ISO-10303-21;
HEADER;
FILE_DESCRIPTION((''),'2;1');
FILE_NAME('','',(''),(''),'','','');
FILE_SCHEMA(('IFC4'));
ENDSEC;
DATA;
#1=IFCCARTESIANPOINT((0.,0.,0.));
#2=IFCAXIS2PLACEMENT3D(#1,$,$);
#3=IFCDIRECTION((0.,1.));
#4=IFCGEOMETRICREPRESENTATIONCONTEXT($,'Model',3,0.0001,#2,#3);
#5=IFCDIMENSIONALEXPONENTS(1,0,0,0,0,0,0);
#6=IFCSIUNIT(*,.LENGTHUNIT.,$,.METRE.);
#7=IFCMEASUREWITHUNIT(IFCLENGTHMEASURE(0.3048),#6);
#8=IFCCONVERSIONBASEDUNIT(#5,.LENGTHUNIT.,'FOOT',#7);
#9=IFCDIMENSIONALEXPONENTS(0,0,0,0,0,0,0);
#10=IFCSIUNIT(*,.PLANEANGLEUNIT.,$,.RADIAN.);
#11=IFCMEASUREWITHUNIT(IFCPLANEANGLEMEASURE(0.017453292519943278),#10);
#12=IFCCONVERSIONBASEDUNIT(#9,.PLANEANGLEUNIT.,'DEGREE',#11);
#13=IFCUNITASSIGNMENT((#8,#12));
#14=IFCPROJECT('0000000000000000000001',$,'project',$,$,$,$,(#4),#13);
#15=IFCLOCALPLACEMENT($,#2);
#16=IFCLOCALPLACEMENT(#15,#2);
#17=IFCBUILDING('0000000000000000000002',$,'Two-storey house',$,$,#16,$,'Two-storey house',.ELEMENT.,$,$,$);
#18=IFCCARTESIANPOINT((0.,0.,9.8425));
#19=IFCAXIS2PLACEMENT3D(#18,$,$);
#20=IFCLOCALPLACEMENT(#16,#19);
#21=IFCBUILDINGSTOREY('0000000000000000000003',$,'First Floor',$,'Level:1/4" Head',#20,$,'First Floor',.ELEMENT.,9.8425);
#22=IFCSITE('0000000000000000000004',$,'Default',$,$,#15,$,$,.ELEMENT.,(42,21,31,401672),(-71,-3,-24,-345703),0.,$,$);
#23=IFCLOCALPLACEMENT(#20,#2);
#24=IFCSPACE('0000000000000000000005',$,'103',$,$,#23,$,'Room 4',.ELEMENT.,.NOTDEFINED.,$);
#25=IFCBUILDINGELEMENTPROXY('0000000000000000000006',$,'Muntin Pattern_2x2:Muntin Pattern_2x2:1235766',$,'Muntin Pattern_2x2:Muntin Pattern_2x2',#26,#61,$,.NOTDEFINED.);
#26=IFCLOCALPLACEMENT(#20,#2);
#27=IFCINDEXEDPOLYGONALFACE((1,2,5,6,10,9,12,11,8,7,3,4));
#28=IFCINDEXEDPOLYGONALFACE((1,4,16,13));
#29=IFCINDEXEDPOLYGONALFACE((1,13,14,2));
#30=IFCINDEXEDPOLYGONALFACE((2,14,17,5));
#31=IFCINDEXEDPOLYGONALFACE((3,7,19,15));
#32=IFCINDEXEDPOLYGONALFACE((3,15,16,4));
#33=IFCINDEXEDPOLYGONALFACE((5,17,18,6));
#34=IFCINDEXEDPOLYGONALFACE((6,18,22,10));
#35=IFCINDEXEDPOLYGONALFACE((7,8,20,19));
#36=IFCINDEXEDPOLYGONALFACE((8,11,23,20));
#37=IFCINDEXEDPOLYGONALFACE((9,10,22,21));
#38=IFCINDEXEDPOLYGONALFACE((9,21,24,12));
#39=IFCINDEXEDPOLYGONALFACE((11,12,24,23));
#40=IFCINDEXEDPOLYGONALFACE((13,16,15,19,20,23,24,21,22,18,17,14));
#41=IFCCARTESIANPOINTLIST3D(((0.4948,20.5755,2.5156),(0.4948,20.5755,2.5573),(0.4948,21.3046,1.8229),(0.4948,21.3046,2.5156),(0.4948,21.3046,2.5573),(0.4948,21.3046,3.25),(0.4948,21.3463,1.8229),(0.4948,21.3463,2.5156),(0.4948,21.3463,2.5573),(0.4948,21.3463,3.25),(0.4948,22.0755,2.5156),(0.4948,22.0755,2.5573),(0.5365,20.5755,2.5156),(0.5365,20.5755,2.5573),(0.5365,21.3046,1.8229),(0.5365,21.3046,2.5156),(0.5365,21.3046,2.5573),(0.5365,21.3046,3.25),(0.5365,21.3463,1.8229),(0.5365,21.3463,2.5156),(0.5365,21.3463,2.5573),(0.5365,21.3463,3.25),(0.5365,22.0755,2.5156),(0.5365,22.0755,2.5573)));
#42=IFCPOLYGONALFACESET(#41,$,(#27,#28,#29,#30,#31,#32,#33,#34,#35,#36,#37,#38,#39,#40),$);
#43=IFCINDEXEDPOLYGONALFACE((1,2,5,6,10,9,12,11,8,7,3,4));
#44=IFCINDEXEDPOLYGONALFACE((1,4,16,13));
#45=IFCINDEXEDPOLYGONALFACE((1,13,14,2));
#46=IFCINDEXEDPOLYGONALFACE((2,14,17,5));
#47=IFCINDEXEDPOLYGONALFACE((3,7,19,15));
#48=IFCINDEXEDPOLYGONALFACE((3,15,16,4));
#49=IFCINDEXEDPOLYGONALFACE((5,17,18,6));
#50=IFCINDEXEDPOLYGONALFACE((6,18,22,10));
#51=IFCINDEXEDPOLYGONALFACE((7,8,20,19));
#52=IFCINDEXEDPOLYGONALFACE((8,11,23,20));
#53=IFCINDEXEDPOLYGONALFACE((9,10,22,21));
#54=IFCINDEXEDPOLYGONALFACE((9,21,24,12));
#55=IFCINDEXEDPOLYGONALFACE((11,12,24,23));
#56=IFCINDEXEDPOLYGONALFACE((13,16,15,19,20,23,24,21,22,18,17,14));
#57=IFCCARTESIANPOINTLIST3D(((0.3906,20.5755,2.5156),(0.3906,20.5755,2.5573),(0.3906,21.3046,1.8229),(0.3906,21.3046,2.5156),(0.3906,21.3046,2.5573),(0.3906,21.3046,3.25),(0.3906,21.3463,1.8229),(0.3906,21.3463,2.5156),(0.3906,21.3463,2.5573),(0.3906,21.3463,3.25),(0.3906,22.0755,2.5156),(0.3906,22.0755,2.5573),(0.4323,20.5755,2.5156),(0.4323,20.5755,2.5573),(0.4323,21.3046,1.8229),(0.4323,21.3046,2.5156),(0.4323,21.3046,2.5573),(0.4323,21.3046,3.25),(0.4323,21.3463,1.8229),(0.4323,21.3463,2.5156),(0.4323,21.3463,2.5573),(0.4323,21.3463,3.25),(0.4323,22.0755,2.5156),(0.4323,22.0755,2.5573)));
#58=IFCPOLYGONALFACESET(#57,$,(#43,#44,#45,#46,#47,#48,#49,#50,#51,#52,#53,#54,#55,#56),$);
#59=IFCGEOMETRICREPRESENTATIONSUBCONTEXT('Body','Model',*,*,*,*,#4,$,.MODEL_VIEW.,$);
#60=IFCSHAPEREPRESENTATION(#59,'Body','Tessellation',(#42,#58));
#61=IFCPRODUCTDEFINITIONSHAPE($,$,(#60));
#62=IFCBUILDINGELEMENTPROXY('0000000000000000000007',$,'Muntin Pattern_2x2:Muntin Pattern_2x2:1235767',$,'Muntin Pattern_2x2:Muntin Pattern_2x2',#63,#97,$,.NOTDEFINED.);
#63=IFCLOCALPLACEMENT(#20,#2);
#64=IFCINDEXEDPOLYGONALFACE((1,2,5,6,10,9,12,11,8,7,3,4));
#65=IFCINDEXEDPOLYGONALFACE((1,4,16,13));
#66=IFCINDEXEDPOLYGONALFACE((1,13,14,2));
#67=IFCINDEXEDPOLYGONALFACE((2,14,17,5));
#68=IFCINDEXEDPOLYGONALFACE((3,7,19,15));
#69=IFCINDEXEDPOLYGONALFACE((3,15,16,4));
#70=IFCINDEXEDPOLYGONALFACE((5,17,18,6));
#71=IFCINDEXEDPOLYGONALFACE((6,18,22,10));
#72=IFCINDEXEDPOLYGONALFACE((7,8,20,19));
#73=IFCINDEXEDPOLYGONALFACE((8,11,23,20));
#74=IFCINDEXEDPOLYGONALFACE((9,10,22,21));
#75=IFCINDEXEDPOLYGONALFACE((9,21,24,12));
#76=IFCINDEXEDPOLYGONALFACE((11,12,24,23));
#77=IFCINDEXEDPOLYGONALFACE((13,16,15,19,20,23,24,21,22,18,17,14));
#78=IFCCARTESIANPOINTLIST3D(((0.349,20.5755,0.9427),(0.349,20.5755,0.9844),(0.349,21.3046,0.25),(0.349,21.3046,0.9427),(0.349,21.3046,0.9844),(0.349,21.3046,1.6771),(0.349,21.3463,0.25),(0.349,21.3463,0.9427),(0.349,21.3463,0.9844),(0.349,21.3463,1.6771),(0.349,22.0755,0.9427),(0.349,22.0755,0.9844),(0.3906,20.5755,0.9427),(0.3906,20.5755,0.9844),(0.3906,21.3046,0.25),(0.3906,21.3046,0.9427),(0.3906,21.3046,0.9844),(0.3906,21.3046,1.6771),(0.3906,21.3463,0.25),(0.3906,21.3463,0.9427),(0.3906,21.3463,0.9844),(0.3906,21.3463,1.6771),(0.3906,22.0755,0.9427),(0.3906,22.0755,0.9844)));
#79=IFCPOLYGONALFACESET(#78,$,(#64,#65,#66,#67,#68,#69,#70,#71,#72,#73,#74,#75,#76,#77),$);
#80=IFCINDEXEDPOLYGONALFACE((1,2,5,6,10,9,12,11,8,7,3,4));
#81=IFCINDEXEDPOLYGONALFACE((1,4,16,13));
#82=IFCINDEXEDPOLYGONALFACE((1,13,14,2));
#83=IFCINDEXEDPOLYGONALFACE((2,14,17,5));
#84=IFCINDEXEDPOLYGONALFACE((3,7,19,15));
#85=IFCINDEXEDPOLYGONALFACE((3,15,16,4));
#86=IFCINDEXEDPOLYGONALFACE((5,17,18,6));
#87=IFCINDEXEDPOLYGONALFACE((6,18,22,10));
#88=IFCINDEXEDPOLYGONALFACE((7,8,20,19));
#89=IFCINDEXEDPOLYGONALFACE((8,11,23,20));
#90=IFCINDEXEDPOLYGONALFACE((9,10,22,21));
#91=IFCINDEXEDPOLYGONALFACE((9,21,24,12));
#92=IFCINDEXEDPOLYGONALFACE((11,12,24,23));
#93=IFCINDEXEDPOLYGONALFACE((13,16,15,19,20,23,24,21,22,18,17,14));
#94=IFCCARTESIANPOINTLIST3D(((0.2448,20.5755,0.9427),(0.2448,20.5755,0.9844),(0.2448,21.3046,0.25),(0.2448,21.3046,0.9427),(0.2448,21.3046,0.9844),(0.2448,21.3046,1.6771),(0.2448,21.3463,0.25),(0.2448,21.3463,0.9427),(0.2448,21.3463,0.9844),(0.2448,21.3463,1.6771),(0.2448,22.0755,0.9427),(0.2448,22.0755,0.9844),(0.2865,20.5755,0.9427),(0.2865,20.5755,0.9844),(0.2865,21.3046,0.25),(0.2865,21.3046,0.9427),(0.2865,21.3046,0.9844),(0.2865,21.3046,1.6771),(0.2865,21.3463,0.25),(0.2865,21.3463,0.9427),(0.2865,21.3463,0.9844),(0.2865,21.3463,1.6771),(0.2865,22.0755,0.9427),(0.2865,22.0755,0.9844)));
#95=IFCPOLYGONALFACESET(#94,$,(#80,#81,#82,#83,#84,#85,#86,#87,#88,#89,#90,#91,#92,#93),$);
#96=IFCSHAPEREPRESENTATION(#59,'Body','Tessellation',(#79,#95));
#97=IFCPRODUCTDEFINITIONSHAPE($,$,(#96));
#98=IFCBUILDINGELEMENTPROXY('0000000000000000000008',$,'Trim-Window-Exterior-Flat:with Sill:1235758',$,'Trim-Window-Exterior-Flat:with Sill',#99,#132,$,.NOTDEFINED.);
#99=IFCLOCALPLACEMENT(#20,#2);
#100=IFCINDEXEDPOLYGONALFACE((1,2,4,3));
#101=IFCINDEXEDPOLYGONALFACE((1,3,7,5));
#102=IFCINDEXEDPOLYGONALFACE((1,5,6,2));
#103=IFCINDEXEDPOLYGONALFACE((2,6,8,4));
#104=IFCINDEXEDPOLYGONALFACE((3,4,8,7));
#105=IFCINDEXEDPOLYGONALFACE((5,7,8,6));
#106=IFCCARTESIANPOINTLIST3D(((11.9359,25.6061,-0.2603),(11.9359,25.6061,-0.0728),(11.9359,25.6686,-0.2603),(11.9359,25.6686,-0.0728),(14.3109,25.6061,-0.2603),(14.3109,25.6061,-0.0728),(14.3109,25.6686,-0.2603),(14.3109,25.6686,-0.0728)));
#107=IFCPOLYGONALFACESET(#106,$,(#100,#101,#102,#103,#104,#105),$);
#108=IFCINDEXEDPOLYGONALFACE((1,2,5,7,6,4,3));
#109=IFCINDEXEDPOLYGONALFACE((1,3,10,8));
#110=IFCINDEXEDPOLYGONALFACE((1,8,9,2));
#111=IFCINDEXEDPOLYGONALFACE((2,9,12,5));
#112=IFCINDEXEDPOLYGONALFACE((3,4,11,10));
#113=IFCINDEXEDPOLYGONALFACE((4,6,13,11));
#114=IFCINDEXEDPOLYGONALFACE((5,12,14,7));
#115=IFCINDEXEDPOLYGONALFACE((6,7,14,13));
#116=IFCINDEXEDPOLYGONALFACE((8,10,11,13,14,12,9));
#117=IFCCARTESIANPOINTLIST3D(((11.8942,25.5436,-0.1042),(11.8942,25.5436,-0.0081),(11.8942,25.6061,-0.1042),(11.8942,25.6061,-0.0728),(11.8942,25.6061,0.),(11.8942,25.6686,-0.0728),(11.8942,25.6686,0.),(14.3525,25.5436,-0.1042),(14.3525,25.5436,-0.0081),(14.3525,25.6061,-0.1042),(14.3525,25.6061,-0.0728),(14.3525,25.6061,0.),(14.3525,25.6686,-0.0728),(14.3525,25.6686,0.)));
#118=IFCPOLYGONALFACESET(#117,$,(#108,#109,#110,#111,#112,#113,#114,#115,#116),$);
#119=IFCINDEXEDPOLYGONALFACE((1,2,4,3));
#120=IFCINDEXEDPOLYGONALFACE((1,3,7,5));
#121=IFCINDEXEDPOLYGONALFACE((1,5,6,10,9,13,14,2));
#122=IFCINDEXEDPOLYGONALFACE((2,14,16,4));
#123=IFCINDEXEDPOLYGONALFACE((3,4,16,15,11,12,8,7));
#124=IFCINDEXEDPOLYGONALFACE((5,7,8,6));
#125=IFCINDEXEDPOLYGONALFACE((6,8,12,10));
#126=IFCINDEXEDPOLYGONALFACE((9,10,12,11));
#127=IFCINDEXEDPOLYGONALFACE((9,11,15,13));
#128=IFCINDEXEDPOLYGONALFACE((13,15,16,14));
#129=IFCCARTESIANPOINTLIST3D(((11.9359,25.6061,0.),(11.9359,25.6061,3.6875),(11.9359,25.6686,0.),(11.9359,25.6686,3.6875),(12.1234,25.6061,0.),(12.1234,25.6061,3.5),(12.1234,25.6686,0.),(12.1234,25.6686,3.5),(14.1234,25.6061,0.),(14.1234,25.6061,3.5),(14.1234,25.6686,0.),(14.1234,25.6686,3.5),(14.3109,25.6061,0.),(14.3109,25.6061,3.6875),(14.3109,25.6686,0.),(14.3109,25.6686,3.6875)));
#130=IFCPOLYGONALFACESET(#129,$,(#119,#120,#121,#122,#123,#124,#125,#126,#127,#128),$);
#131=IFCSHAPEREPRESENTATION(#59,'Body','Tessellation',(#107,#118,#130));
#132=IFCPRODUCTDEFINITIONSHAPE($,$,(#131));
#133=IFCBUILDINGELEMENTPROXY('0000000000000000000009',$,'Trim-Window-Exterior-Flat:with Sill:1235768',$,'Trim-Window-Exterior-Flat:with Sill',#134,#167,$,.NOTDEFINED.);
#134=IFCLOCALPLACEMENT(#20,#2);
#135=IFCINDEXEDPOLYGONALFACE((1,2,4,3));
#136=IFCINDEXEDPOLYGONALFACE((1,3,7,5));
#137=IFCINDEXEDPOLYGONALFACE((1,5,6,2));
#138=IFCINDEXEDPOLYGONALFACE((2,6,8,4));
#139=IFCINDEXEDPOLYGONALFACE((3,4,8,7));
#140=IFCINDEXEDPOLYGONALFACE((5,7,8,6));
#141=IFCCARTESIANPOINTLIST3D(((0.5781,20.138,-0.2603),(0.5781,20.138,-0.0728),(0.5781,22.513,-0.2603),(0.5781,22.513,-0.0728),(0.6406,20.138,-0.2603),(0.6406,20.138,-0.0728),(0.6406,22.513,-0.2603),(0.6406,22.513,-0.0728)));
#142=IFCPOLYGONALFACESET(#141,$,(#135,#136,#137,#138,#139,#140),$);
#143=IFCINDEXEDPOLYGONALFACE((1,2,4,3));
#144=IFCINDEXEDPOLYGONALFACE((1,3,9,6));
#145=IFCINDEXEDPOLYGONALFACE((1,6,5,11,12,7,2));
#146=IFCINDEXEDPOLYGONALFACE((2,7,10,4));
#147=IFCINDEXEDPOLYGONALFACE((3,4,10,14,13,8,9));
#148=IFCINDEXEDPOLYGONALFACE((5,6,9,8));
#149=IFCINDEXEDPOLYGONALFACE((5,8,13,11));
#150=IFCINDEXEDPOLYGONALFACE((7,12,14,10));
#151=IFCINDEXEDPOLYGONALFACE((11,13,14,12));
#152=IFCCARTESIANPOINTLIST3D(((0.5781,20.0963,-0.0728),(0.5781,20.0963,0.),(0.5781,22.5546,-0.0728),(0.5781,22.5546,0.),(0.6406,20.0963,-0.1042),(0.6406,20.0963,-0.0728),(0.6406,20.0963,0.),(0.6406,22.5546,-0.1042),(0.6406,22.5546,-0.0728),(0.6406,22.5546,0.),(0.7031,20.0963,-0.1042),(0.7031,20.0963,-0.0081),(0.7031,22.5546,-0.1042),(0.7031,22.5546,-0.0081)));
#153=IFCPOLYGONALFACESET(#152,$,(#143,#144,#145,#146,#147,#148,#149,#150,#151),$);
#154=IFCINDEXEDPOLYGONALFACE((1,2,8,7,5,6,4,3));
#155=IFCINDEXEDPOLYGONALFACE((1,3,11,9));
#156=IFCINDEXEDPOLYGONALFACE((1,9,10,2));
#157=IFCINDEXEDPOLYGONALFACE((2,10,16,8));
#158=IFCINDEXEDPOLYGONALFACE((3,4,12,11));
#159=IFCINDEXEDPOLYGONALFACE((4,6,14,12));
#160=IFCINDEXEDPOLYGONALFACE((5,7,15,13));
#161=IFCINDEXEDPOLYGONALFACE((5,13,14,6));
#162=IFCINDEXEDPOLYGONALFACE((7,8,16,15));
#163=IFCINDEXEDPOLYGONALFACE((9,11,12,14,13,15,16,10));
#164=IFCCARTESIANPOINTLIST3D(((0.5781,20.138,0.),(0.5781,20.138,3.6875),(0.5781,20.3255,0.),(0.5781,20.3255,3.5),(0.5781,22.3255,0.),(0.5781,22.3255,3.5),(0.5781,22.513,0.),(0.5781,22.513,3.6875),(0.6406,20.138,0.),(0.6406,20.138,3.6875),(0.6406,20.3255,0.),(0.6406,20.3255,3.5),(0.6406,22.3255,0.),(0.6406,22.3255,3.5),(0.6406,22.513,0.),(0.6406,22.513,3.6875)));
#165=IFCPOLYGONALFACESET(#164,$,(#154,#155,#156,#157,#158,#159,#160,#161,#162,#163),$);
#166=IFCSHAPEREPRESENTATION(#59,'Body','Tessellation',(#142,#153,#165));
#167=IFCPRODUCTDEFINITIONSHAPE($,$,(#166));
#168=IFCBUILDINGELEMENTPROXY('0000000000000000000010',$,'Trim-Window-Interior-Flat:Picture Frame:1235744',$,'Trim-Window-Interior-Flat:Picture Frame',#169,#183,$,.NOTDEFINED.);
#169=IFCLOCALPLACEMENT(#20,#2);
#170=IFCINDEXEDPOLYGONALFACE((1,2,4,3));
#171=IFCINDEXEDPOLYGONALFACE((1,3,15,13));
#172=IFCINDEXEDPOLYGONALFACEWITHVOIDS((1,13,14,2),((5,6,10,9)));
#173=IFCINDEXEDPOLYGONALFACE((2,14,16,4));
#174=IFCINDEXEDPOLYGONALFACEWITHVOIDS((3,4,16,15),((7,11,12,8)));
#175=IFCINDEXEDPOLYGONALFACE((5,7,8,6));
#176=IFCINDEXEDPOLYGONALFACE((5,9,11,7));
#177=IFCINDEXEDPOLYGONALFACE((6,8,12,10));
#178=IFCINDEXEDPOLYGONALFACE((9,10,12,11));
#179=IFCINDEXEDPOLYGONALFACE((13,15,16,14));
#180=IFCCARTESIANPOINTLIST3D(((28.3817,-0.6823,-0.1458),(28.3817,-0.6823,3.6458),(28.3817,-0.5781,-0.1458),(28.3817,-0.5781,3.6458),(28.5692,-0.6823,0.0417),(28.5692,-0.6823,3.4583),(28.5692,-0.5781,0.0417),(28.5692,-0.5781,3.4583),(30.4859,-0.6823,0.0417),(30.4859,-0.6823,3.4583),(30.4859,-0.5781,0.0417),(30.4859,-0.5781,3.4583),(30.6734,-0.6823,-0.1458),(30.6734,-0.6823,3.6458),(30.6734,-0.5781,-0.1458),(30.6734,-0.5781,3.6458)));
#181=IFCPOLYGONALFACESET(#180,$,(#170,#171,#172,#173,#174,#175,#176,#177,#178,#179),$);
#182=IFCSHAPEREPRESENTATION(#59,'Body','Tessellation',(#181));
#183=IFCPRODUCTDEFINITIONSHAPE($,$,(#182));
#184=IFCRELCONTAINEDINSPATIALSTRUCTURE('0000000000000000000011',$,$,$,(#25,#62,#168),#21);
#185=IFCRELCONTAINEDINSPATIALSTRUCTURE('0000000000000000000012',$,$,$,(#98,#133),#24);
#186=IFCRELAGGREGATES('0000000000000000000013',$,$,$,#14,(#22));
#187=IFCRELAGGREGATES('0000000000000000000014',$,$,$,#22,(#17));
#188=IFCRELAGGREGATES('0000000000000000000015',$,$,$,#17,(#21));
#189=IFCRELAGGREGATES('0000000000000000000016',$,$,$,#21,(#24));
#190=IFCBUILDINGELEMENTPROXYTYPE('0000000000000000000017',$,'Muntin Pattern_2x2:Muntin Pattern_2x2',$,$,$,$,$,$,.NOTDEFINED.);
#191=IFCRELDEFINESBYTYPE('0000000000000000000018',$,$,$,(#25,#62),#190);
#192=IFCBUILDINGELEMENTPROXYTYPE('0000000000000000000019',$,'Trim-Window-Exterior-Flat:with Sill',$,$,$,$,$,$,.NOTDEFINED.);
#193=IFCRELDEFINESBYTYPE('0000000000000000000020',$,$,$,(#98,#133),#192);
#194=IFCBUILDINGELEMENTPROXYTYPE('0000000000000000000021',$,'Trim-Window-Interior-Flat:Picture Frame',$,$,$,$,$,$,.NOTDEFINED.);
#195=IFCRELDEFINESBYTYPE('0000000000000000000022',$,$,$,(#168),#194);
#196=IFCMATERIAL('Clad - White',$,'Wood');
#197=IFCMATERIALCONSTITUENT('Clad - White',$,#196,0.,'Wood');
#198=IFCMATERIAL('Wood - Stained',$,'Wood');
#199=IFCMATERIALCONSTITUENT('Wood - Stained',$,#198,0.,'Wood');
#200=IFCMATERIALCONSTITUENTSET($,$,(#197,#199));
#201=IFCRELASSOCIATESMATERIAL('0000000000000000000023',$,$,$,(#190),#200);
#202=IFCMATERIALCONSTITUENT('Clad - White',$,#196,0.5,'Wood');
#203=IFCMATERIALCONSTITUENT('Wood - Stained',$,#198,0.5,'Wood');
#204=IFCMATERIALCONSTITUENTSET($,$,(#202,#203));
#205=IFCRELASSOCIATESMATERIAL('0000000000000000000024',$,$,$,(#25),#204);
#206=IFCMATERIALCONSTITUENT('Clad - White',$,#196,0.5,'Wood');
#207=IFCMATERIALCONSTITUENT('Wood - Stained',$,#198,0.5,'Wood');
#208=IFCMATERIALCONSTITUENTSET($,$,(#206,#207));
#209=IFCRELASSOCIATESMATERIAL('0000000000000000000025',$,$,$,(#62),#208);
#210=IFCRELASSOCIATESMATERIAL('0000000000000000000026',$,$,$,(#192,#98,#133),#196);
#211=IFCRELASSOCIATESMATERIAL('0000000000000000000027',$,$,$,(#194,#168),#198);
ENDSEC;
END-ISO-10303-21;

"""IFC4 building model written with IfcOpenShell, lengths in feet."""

from ifc_helpers import new_model, entity, si_unit, converted_unit, direction, frame, origin, place, context, subcontext, project, spatial, indexed_curve, outline, extrude, source, transform, mapped, material, constituent, constituent_set, type_object, type_shapes, element, save


model = new_model("IFC4")

# Units and contexts
model_context = context("Model", 3, precision=0.0001, world=origin(), true_north=direction((0.0, 1.0)))
body_context = subcontext(model_context, "Body", "Model", "MODEL_VIEW")
ifc_project = project(units=[converted_unit("LENGTHUNIT", "FOOT", entity("IfcLengthMeasure", 0.3048), si_unit("LENGTHUNIT", "METRE"), dimensions=[1, 0, 0, 0, 0, 0, 0]), converted_unit("PLANEANGLEUNIT", "DEGREE", entity("IfcPlaneAngleMeasure", 0.017453292519943278), si_unit("PLANEANGLEUNIT", "RADIAN"), dimensions=[0, 0, 0, 0, 0, 0, 0])], contexts=[model_context])

# Site, building, storey
site_placement = place(None, origin())
site = spatial("IfcSite", under=ifc_project, at=site_placement, Name="Default", CompositionType="ELEMENT", RefLatitude=(42, 21, 31, 401672), RefLongitude=(-71, -3, -24, -345703), RefElevation=0.0)
building_placement = place(site_placement, origin())
building = spatial("IfcBuilding", under=site, at=building_placement, Name="Two-storey house", LongName="Two-storey house", CompositionType="ELEMENT")
storey_placement = place(building_placement, frame((0.0, 0.0, 9.8425)))
storey = spatial("IfcBuildingStorey", under=building, at=storey_placement, Name="First Floor", ObjectType="Level:1/4\" Head", LongName="First Floor", CompositionType="ELEMENT", Elevation=9.8425)

# Shared definitions
ifc_material_1 = material(Name="Wood - Stained", Category="Wood")

# Building element proxies
ifc_material_2 = material(Name="Clad - White", Category="Wood")
ifc_constituent_1 = constituent(ifc_material_2, Name="Clad - White", Category="Wood", fraction=0.0)
ifc_constituent_2 = constituent(ifc_material_1, Name="Wood - Stained", Category="Wood", fraction=0.0)
ifc_constituent_set_1 = constituent_set(constituents=[ifc_constituent_1, ifc_constituent_2])
building_element_proxy_type_1 = type_object("IfcBuildingElementProxyType", Name="Muntin Pattern_2x2:Muntin Pattern_2x2", PredefinedType="NOTDEFINED", material=ifc_constituent_set_1)
shared_shape_1 = source(origin(), body_context, "Body", "SweptSolid", [
    extrude(outline(indexed_curve([(0.0208, -0.0208), (0.7135, -0.0208), (0.7135, 0.0208), (0.0208, 0.0208), (0.0208, 0.75), (-0.0208, 0.75), (-0.0208, 0.0208), (-0.7135, 0.0208), (-0.7135, -0.0208), (-0.0208, -0.0208), (-0.0208, -0.75), (0.0208, -0.75), (0.0208, -0.0208)], self_intersect=False)), frame((0.0, 0.0312, 0.7135), z_axis=(0.0, 1.0, 0.0), x_axis=(0.0, 0.0, 1.0)), (0.0, 0.0, 1.0), 0.0417),
    extrude(outline(indexed_curve([(0.0208, -0.0208), (0.7135, -0.0208), (0.7135, 0.0208), (0.0208, 0.0208), (0.0208, 0.75), (-0.0208, 0.75), (-0.0208, 0.0208), (-0.7135, 0.0208), (-0.7135, -0.0208), (-0.0208, -0.0208), (-0.0208, -0.75), (0.0208, -0.75), (0.0208, -0.0208)], self_intersect=False)), frame((0.0, -0.0729, 0.7135), z_axis=(0.0, 1.0, 0.0), x_axis=(0.0, 0.0, 1.0)), (0.0, 0.0, 1.0), 0.0417),
])
type_shapes(building_element_proxy_type_1, [shared_shape_1])
ifc_constituent_3 = constituent(ifc_material_2, Name="Clad - White", Category="Wood", fraction=0.5)
ifc_constituent_4 = constituent(ifc_material_1, Name="Wood - Stained", Category="Wood", fraction=0.5)
ifc_constituent_set_2 = constituent_set(constituents=[ifc_constituent_3, ifc_constituent_4])
proxy_1_placement = place(storey_placement, frame((0.4635, 21.3255, 1.8229), z_axis=(0.0, 0.0, 1.0), x_axis=(0.0, -1.0, 0.0)))
element("IfcBuildingElementProxy", 1, at=proxy_1_placement, inside=storey, type_object=building_element_proxy_type_1, material=ifc_constituent_set_2, Name="Muntin Pattern_2x2:Muntin Pattern_2x2:1235766", ObjectType="Muntin Pattern_2x2:Muntin Pattern_2x2", PredefinedType="NOTDEFINED", context=body_context, shape_type="MappedRepresentation", body=[
    mapped(shared_shape_1, transform((0.0, 0.0, 0.0), scale=1.0)),
])
ifc_constituent_5 = constituent(ifc_material_2, Name="Clad - White", Category="Wood", fraction=0.5)
ifc_constituent_6 = constituent(ifc_material_1, Name="Wood - Stained", Category="Wood", fraction=0.5)
ifc_constituent_set_3 = constituent_set(constituents=[ifc_constituent_5, ifc_constituent_6])
proxy_2_placement = place(storey_placement, frame((0.3177, 21.3255, 0.25), z_axis=(0.0, 0.0, 1.0), x_axis=(0.0, -1.0, 0.0)))
element("IfcBuildingElementProxy", 2, at=proxy_2_placement, inside=storey, type_object=building_element_proxy_type_1, material=ifc_constituent_set_3, Name="Muntin Pattern_2x2:Muntin Pattern_2x2:1235767", ObjectType="Muntin Pattern_2x2:Muntin Pattern_2x2", PredefinedType="NOTDEFINED", context=body_context, shape_type="MappedRepresentation", body=[
    mapped(shared_shape_1, transform((0.0, 0.0, 0.0), scale=1.0)),
])

# Shared definitions
space_placement = place(storey_placement, origin())
space = spatial("IfcSpace", under=storey, at=space_placement, Name="103", LongName="Room 4", CompositionType="ELEMENT", PredefinedType="NOTDEFINED")

# Building element proxies
building_element_proxy_type_2 = type_object("IfcBuildingElementProxyType", Name="Trim-Window-Exterior-Flat:with Sill", PredefinedType="NOTDEFINED", material=ifc_material_2)
shared_shape_2 = source(origin(), body_context, "Body", "SweptSolid", [
    extrude(outline(indexed_curve([(-1.1875, -0.0938), (1.1875, -0.0938), (1.1875, 0.0938), (-1.1875, 0.0938), (-1.1875, -0.0938)], self_intersect=False)), frame((0.0, -3.6665, 0.0), z_axis=(0.0, 0.0, 1.0), x_axis=(-1.0, 0.0, 0.0)), (0.0, 0.0, 1.0), 0.0625),
    extrude(outline(indexed_curve([(-0.0625, -0.0525), (0.0, -0.0525), (0.0, -0.0211), (0.0625, -0.0211), (0.0625, 0.0517), (0.0, 0.0517), (-0.0625, 0.0436), (-0.0625, -0.0525)], self_intersect=False)), frame((-1.2292, -3.5517, 0.0625), z_axis=(1.0, 0.0, 0.0), x_axis=(0.0, 0.0, -1.0)), (0.0, 0.0, 1.0), 2.4583),
    extrude(outline(indexed_curve([(-1.8906, -1.1875), (1.7969, -1.1875), (1.7969, -1.0), (-1.7031, -1.0), (-1.7031, 1.0), (1.7969, 1.0), (1.7969, 1.1875), (-1.8906, 1.1875), (-1.8906, -1.1875)], self_intersect=False)), frame((0.0, -1.7031, 0.0), z_axis=(0.0, 0.0, 1.0), x_axis=(0.0, -1.0, 0.0)), (0.0, 0.0, 1.0), 0.0625),
])
type_shapes(building_element_proxy_type_2, [shared_shape_2])
for number, where, z_axis, x_axis, name in (
    (3, (13.1234, 25.6686, 3.5), (0.0, -1.0, 0.0), (1.0, 0.0, 0.0), "Trim-Window-Exterior-Flat:with Sill:1235758"),
    (4, (0.5781, 21.3255, 3.5), (1.0, 0.0, 0.0), (0.0, 1.0, 0.0), "Trim-Window-Exterior-Flat:with Sill:1235768"),
):
    element("IfcBuildingElementProxy", number, at=place(space_placement, frame(where, z_axis=z_axis, x_axis=x_axis)), inside=space, type_object=building_element_proxy_type_2, material=ifc_material_2, Name=name, ObjectType="Trim-Window-Exterior-Flat:with Sill", PredefinedType="NOTDEFINED", context=body_context, shape_type="MappedRepresentation", body=[
        mapped(shared_shape_2, transform((0.0, 0.0, 0.0), scale=1.0)),
    ])
building_element_proxy_type_3 = type_object("IfcBuildingElementProxyType", Name="Trim-Window-Interior-Flat:Picture Frame", PredefinedType="NOTDEFINED", material=ifc_material_1)
shared_shape_3 = source(origin(), body_context, "Body", "SweptSolid", [
    extrude(outline(indexed_curve([(-1.1458, -1.8958), (1.1458, -1.8958), (1.1458, 1.8958), (-1.1458, 1.8958), (-1.1458, -1.8958)], self_intersect=False), holes=[indexed_curve([(-0.9583, -1.7083), (-0.9583, 1.7083), (0.9583, 1.7083), (0.9583, -1.7083), (-0.9583, -1.7083)], self_intersect=False)]), frame((0.0, -1.75, 0.0), z_axis=(0.0, 0.0, 1.0), x_axis=(-1.0, 0.0, 0.0)), (0.0, 0.0, 1.0), 0.1042),
])
type_shapes(building_element_proxy_type_3, [shared_shape_3])
for number, where, z_axis, x_axis, name in (
    (5, (29.5276, -0.5781, 3.5), (0.0, -1.0, 0.0), (1.0, 0.0, 0.0), "Trim-Window-Interior-Flat:Picture Frame:1235744"),
):
    element("IfcBuildingElementProxy", number, at=place(storey_placement, frame(where, z_axis=z_axis, x_axis=x_axis)), inside=storey, type_object=building_element_proxy_type_3, material=ifc_material_1, Name=name, ObjectType="Trim-Window-Interior-Flat:Picture Frame", PredefinedType="NOTDEFINED", context=body_context, shape_type="MappedRepresentation", body=[
        mapped(shared_shape_3, transform((0.0, 0.0, 0.0), scale=1.0)),
    ])

save(model, "model.ifc")
